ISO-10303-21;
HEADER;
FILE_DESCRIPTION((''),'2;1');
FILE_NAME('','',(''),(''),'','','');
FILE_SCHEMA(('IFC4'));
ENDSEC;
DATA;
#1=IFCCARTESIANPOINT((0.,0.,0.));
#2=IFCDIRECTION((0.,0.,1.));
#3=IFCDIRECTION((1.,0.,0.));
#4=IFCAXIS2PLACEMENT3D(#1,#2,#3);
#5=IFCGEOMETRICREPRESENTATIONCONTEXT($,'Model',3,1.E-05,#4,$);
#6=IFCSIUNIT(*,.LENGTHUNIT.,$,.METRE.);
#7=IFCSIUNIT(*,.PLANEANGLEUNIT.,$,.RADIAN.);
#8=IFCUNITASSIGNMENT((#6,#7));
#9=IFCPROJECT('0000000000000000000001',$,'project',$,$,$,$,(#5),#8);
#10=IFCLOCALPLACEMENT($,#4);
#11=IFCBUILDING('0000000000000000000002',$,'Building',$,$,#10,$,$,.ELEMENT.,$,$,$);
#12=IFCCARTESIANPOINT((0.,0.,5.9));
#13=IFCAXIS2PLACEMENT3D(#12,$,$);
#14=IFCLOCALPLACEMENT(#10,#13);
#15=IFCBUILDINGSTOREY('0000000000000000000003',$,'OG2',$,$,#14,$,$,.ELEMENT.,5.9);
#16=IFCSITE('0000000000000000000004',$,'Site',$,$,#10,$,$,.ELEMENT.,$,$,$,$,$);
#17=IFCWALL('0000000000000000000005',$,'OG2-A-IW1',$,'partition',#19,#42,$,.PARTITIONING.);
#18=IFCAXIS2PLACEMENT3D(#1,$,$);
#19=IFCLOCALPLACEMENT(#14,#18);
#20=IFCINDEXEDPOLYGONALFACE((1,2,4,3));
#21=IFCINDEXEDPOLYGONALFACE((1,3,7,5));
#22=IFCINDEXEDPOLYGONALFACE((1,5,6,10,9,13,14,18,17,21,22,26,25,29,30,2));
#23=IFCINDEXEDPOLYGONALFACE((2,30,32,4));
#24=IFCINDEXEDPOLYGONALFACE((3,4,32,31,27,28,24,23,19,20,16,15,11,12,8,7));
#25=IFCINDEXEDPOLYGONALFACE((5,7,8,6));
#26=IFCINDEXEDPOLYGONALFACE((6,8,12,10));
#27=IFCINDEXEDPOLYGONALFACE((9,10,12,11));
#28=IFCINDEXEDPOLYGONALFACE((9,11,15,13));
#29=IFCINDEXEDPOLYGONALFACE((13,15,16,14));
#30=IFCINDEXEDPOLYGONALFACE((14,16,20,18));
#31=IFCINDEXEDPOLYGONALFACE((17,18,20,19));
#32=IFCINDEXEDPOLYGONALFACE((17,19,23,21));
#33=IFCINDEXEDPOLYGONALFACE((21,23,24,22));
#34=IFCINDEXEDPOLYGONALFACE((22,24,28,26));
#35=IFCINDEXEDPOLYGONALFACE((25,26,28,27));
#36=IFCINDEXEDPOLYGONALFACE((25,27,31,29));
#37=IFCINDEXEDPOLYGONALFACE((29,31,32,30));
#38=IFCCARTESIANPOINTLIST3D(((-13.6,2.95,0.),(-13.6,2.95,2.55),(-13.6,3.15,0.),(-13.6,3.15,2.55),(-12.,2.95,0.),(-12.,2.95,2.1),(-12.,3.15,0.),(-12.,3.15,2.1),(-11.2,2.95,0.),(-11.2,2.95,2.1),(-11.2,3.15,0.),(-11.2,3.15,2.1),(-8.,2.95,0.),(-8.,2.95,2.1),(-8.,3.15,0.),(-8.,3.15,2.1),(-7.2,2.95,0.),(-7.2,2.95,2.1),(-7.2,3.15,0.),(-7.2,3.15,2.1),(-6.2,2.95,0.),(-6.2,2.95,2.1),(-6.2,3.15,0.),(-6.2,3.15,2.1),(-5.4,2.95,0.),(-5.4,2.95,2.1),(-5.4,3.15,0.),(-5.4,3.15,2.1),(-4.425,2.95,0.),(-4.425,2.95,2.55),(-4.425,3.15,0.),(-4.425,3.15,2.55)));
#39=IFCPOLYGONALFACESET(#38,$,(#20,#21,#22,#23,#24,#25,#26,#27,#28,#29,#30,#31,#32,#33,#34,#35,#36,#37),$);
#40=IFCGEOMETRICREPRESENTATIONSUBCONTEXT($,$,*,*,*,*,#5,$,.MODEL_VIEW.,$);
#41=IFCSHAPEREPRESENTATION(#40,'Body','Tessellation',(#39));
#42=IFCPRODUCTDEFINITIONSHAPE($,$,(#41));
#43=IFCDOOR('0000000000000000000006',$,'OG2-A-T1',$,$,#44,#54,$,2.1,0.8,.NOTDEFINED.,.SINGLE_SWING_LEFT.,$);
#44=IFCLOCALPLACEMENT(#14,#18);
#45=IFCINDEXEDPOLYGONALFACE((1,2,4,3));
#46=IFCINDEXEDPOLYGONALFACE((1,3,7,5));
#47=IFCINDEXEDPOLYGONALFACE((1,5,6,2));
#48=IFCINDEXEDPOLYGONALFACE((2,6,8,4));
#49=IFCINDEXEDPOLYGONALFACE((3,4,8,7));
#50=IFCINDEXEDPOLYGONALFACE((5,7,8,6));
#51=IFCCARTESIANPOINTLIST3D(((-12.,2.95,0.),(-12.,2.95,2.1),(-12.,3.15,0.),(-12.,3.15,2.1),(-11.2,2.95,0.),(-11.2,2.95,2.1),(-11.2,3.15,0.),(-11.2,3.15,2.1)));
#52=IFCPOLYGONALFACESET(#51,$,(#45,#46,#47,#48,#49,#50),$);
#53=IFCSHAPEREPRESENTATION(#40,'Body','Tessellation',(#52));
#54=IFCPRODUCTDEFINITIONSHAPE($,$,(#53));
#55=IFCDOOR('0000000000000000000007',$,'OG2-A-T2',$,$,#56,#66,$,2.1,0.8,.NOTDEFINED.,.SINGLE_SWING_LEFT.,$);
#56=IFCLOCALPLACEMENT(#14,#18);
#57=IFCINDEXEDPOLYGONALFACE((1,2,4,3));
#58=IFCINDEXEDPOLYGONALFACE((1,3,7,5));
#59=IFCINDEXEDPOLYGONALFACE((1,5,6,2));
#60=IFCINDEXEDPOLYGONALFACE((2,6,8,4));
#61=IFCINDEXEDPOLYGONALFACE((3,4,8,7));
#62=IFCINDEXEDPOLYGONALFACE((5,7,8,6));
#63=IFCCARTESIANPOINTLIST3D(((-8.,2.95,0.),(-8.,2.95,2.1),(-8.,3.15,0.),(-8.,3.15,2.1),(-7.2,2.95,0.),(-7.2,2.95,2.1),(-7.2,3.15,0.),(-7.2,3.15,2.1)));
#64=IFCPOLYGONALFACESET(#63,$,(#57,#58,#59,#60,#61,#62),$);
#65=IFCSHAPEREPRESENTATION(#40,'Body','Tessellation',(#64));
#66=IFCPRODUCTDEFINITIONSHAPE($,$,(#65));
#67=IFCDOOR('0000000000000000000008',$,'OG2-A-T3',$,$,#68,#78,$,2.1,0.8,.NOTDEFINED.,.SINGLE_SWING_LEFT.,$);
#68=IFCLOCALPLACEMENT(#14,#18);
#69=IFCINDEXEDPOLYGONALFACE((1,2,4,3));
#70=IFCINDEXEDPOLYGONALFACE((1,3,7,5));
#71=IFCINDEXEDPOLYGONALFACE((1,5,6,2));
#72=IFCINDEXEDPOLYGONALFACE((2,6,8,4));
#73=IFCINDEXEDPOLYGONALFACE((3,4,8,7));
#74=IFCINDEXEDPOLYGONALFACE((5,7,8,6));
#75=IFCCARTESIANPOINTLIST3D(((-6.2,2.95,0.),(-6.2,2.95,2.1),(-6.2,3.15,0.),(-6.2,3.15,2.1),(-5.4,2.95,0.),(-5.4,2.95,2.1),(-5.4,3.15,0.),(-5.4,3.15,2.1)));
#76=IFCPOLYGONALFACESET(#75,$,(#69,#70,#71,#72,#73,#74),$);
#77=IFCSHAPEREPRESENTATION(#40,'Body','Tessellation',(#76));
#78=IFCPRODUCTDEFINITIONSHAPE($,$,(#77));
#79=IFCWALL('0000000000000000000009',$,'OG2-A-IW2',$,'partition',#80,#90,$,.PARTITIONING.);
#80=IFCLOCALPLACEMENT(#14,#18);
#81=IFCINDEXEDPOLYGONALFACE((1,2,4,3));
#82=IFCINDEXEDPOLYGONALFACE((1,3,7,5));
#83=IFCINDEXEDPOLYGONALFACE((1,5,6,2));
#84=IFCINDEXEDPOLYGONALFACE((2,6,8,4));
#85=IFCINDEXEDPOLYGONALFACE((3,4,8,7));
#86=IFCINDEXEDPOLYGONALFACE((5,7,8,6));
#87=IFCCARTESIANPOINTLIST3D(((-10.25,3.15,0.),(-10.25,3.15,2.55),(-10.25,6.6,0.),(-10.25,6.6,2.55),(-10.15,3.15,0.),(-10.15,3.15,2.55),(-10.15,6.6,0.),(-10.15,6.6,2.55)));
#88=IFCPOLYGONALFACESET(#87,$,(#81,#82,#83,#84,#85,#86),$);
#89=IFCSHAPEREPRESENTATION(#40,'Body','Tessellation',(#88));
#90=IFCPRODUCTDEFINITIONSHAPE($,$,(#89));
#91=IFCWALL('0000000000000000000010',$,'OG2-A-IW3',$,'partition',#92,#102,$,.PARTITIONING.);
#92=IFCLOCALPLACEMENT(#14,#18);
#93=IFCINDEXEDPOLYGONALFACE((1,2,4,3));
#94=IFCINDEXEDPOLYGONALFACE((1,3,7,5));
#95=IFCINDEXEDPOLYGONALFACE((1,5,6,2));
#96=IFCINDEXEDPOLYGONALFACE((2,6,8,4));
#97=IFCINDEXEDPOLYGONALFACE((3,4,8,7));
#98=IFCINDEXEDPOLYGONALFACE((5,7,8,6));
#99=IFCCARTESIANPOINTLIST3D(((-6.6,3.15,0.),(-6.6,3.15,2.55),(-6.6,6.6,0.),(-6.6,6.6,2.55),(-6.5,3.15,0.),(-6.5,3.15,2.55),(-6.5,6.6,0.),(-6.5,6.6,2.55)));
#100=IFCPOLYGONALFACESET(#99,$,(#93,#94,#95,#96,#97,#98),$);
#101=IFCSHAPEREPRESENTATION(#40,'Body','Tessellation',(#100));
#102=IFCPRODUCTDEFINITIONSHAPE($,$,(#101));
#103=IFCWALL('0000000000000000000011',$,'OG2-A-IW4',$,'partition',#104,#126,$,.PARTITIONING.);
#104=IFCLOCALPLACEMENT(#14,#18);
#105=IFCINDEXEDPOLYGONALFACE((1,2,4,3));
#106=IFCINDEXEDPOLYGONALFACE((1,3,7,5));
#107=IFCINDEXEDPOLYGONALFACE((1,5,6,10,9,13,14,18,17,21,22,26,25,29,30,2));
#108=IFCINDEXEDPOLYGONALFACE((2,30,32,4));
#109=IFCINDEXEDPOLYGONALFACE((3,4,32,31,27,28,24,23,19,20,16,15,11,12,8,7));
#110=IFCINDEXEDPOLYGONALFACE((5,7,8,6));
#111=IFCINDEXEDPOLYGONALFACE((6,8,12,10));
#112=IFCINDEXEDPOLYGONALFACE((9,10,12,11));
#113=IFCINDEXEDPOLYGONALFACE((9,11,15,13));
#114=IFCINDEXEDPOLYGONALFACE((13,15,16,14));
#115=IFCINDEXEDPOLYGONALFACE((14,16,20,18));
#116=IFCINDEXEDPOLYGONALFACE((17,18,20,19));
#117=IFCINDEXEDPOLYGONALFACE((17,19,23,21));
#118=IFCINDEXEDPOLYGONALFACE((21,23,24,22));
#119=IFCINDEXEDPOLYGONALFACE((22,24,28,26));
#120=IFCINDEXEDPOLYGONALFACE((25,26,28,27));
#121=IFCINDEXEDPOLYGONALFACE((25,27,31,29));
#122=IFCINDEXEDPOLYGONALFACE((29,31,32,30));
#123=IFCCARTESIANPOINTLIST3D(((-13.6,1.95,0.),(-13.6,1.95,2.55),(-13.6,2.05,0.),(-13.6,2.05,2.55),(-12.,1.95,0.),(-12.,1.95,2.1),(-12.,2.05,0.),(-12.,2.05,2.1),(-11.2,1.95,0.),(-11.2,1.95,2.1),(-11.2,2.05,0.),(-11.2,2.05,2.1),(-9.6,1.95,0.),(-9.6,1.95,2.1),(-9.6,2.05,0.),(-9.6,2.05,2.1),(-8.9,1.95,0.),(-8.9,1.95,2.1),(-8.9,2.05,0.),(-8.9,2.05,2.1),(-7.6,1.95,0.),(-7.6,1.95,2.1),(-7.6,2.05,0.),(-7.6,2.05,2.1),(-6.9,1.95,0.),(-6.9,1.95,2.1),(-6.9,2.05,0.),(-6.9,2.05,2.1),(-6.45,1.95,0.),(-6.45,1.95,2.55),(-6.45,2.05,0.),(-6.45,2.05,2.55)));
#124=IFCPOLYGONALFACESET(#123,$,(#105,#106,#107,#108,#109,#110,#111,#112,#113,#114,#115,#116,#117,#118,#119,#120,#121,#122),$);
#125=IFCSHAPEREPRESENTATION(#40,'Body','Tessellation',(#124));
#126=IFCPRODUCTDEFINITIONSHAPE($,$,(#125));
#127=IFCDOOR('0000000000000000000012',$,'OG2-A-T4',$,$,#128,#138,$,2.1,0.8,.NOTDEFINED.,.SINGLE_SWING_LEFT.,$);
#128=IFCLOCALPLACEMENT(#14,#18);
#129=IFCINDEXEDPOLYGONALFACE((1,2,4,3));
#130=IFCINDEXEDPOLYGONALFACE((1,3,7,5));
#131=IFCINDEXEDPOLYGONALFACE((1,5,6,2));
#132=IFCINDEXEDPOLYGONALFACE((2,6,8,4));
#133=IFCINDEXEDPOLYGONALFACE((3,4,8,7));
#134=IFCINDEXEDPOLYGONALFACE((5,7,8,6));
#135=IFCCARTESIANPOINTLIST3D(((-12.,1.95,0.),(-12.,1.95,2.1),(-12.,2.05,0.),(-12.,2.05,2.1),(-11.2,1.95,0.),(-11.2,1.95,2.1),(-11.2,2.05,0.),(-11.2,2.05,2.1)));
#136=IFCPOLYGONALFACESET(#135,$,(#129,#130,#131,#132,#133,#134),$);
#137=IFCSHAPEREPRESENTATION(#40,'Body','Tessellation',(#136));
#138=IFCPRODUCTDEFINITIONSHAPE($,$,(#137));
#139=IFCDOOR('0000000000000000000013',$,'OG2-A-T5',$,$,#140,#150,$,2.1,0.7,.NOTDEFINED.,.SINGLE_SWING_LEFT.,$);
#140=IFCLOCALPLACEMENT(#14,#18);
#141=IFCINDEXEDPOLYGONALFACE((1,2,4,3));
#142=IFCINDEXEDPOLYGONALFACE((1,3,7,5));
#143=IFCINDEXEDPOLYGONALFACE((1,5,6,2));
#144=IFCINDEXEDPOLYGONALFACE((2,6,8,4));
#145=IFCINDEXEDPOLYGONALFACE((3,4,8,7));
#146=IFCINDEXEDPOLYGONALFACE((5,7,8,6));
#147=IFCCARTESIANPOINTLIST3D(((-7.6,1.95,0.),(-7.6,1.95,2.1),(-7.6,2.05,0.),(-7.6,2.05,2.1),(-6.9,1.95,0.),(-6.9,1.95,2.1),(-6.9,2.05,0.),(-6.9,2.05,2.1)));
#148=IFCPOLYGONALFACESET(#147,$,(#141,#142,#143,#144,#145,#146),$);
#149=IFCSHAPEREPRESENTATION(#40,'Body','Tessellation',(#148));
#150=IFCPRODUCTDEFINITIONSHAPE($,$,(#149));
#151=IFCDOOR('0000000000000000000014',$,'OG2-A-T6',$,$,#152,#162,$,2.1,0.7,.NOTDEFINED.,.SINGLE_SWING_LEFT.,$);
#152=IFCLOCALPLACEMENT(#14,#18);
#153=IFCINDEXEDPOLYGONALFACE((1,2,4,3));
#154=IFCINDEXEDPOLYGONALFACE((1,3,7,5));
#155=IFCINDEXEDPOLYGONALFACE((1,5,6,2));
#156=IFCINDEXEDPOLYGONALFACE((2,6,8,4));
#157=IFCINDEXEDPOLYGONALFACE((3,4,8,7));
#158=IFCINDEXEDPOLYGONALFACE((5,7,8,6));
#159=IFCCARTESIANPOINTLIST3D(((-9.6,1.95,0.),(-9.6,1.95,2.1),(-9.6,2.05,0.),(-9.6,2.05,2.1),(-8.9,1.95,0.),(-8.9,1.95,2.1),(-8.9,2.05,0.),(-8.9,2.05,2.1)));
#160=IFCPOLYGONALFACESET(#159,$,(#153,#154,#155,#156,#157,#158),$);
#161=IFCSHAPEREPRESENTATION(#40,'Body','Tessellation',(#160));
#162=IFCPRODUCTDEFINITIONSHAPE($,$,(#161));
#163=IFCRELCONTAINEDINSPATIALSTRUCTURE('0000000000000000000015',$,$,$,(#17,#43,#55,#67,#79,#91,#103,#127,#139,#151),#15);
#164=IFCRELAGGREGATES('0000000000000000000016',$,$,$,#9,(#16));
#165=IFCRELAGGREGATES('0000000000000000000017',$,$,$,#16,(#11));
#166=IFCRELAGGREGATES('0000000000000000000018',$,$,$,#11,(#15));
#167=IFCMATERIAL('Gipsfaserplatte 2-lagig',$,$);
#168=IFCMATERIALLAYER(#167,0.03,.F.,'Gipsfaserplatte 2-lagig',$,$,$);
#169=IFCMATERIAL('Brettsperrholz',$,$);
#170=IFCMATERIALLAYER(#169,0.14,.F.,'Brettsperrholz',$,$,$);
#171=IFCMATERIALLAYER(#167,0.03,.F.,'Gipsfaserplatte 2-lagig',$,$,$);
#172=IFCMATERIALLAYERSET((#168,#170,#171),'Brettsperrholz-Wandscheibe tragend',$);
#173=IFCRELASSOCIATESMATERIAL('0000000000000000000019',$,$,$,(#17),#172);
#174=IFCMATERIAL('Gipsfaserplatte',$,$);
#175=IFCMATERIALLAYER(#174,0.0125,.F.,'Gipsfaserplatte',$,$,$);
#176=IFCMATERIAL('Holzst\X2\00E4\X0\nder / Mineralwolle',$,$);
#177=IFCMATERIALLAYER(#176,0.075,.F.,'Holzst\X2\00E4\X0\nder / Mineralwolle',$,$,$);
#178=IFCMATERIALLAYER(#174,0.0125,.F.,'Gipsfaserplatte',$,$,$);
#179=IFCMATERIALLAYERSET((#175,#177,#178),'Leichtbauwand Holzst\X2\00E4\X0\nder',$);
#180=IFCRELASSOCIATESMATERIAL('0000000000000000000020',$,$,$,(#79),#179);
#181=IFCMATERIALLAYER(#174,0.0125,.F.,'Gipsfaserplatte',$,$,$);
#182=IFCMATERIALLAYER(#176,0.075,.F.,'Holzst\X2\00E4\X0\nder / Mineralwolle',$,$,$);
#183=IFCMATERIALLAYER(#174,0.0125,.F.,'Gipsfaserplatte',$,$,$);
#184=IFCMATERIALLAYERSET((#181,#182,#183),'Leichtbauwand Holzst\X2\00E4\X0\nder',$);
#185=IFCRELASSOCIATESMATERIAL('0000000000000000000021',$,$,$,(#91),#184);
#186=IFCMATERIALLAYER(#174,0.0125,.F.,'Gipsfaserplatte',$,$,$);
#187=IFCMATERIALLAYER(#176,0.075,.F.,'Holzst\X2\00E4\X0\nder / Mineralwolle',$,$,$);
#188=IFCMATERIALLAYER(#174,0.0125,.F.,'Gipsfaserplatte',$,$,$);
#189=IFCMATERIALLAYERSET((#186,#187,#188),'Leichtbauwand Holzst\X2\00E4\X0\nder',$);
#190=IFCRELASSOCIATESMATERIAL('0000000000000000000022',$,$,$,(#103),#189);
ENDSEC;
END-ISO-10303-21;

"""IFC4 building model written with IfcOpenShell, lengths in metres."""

from ifc_helpers import new_model, si_unit, frame, frame_2d, origin, origin_with_axes, place, context, subcontext, project, spatial, rectangle, extrude, material, layer, layer_set, element, fill, save


model = new_model("IFC4")

# Units and contexts
model_context = context("Model", 3, precision=1e-05, world=origin_with_axes())
sub_context = subcontext(model_context, None, None, "MODEL_VIEW")
ifc_project = project(units=[si_unit("LENGTHUNIT", "METRE"), si_unit("PLANEANGLEUNIT", "RADIAN")], contexts=[model_context])

# Site, building, storey
placement = place(None, origin_with_axes())
site = spatial("IfcSite", under=ifc_project, at=placement, Name="Site", CompositionType="ELEMENT")
building = spatial("IfcBuilding", under=site, at=placement, Name="Building", CompositionType="ELEMENT")
storey_placement = place(placement, frame((0.0, 0.0, 5.9)))
storey = spatial("IfcBuildingStorey", under=building, at=storey_placement, Name="OG2", CompositionType="ELEMENT", Elevation=5.9)

# Shared definitions
ifc_material_1 = material(Name="Gipsfaserplatte")

# Wall, openings, doors
ifc_material_2 = material(Name="Gipsfaserplatte 2-lagig")
ifc_layer_1 = layer(ifc_material_2, 0.03, ventilated=False, Name="Gipsfaserplatte 2-lagig")
ifc_material_3 = material(Name="Brettsperrholz")
ifc_layer_2 = layer(ifc_material_3, 0.14, ventilated=False, Name="Brettsperrholz")
ifc_layer_3 = layer(ifc_material_2, 0.03, ventilated=False, Name="Gipsfaserplatte 2-lagig")
ifc_layer_set_1 = layer_set([ifc_layer_1, ifc_layer_2, ifc_layer_3], Name="Brettsperrholz-Wandscheibe tragend")
wall_1_placement = place(storey_placement, frame((-13.6, 3.05, 0.0), z_axis=(0.0, 0.0, 1.0), x_axis=(1.0, 0.0, 0.0)))
wall_1 = element("IfcWall", 1, at=wall_1_placement, inside=storey, material=ifc_layer_set_1, Name="OG2-A-IW1", ObjectType="partition", PredefinedType="PARTITIONING", context=sub_context, shape_type="SweptSolid", body=[
    extrude(rectangle(XDim=9.175, YDim=0.2, at=frame_2d((4.5875, 0.0))), origin(), (0.0, 0.0, 1.0), 2.55),
])
opening_1_placement = place(wall_1_placement, frame((2.0, 0.15, 0.0), z_axis=(0.0, -1.0, 0.0), x_axis=(1.0, 0.0, 0.0)))
opening_1 = element("IfcOpeningElement", 2, at=opening_1_placement, cuts=wall_1, PredefinedType="OPENING", context=sub_context, shape_type="SweptSolid", body=[
    extrude(rectangle(XDim=0.8, YDim=2.1, at=frame_2d((0.0, 1.05))), origin(), (0.0, 0.0, 1.0), 0.3),
])
opening_2_placement = place(wall_1_placement, frame((6.0, 0.15, 0.0), z_axis=(0.0, -1.0, 0.0), x_axis=(1.0, 0.0, 0.0)))
opening_2 = element("IfcOpeningElement", 3, at=opening_2_placement, cuts=wall_1, PredefinedType="OPENING", context=sub_context, shape_type="SweptSolid", body=[
    extrude(rectangle(XDim=0.8, YDim=2.1, at=frame_2d((0.0, 1.05))), origin(), (0.0, 0.0, 1.0), 0.3),
])
opening_3_placement = place(wall_1_placement, frame((7.8, 0.15, 0.0), z_axis=(0.0, -1.0, 0.0), x_axis=(1.0, 0.0, 0.0)))
opening_3 = element("IfcOpeningElement", 4, at=opening_3_placement, cuts=wall_1, PredefinedType="OPENING", context=sub_context, shape_type="SweptSolid", body=[
    extrude(rectangle(XDim=0.8, YDim=2.1, at=frame_2d((0.0, 1.05))), origin(), (0.0, 0.0, 1.0), 0.3),
])
door_1_placement = place(wall_1_placement, frame((2.0, 0.1, 0.0), z_axis=(0.0, -1.0, 0.0), x_axis=(1.0, 0.0, 0.0)))
door_1 = element("IfcDoor", 5, at=door_1_placement, inside=storey, Name="OG2-A-T1", OperationType="SINGLE_SWING_LEFT", OverallHeight=2.1, OverallWidth=0.8, PredefinedType="NOTDEFINED", context=sub_context, shape_type="SweptSolid", body=[
    extrude(rectangle(XDim=0.8, YDim=2.1, at=frame_2d((0.0, 1.05))), origin(), (0.0, 0.0, 1.0), 0.2),
])
fill(opening_1, door_1)
door_2_placement = place(wall_1_placement, frame((6.0, 0.1, 0.0), z_axis=(0.0, -1.0, 0.0), x_axis=(1.0, 0.0, 0.0)))
door_2 = element("IfcDoor", 6, at=door_2_placement, inside=storey, Name="OG2-A-T2", OperationType="SINGLE_SWING_LEFT", OverallHeight=2.1, OverallWidth=0.8, PredefinedType="NOTDEFINED", context=sub_context, shape_type="SweptSolid", body=[
    extrude(rectangle(XDim=0.8, YDim=2.1, at=frame_2d((0.0, 1.05))), origin(), (0.0, 0.0, 1.0), 0.2),
])
fill(opening_2, door_2)
door_3_placement = place(wall_1_placement, frame((7.8, 0.1, 0.0), z_axis=(0.0, -1.0, 0.0), x_axis=(1.0, 0.0, 0.0)))
door_3 = element("IfcDoor", 7, at=door_3_placement, inside=storey, Name="OG2-A-T3", OperationType="SINGLE_SWING_LEFT", OverallHeight=2.1, OverallWidth=0.8, PredefinedType="NOTDEFINED", context=sub_context, shape_type="SweptSolid", body=[
    extrude(rectangle(XDim=0.8, YDim=2.1, at=frame_2d((0.0, 1.05))), origin(), (0.0, 0.0, 1.0), 0.2),
])
fill(opening_3, door_3)

# Walls
ifc_layer_4 = layer(ifc_material_1, 0.0125, ventilated=False, Name="Gipsfaserplatte")
ifc_material_4 = material(Name="Holzständer / Mineralwolle")
ifc_layer_5 = layer(ifc_material_4, 0.075, ventilated=False, Name="Holzständer / Mineralwolle")
ifc_layer_6 = layer(ifc_material_1, 0.0125, ventilated=False, Name="Gipsfaserplatte")
ifc_layer_set_2 = layer_set([ifc_layer_4, ifc_layer_5, ifc_layer_6], Name="Leichtbauwand Holzständer")
wall_2_placement = place(storey_placement, frame((-10.2, 3.15, 0.0), z_axis=(0.0, 0.0, 1.0), x_axis=(0.0, 1.0, 0.0)))
element("IfcWall", 8, at=wall_2_placement, inside=storey, material=ifc_layer_set_2, Name="OG2-A-IW2", ObjectType="partition", PredefinedType="PARTITIONING", context=sub_context, shape_type="SweptSolid", body=[
    extrude(rectangle(XDim=3.45, YDim=0.1, at=frame_2d((1.725, 0.0))), origin(), (0.0, 0.0, 1.0), 2.55),
])
ifc_layer_7 = layer(ifc_material_1, 0.0125, ventilated=False, Name="Gipsfaserplatte")
ifc_layer_8 = layer(ifc_material_4, 0.075, ventilated=False, Name="Holzständer / Mineralwolle")
ifc_layer_9 = layer(ifc_material_1, 0.0125, ventilated=False, Name="Gipsfaserplatte")
ifc_layer_set_3 = layer_set([ifc_layer_7, ifc_layer_8, ifc_layer_9], Name="Leichtbauwand Holzständer")
wall_3_placement = place(storey_placement, frame((-6.55, 3.15, 0.0), z_axis=(0.0, 0.0, 1.0), x_axis=(0.0, 1.0, 0.0)))
element("IfcWall", 9, at=wall_3_placement, inside=storey, material=ifc_layer_set_3, Name="OG2-A-IW3", ObjectType="partition", PredefinedType="PARTITIONING", context=sub_context, shape_type="SweptSolid", body=[
    extrude(rectangle(XDim=3.45, YDim=0.1, at=frame_2d((1.725, 0.0))), origin(), (0.0, 0.0, 1.0), 2.55),
])

# Wall, openings, doors
ifc_layer_10 = layer(ifc_material_1, 0.0125, ventilated=False, Name="Gipsfaserplatte")
ifc_layer_11 = layer(ifc_material_4, 0.075, ventilated=False, Name="Holzständer / Mineralwolle")
ifc_layer_12 = layer(ifc_material_1, 0.0125, ventilated=False, Name="Gipsfaserplatte")
ifc_layer_set_4 = layer_set([ifc_layer_10, ifc_layer_11, ifc_layer_12], Name="Leichtbauwand Holzständer")
wall_4_placement = place(storey_placement, frame((-13.6, 2.0, 0.0), z_axis=(0.0, 0.0, 1.0), x_axis=(1.0, 0.0, 0.0)))
wall_4 = element("IfcWall", 10, at=wall_4_placement, inside=storey, material=ifc_layer_set_4, Name="OG2-A-IW4", ObjectType="partition", PredefinedType="PARTITIONING", context=sub_context, shape_type="SweptSolid", body=[
    extrude(rectangle(XDim=7.15, YDim=0.1, at=frame_2d((3.575, 0.0))), origin(), (0.0, 0.0, 1.0), 2.55),
])
opening_4_placement = place(wall_4_placement, frame((2.0, 0.1, 0.0), z_axis=(0.0, -1.0, 0.0), x_axis=(1.0, 0.0, 0.0)))
opening_4 = element("IfcOpeningElement", 11, at=opening_4_placement, cuts=wall_4, PredefinedType="OPENING", context=sub_context, shape_type="SweptSolid", body=[
    extrude(rectangle(XDim=0.8, YDim=2.1, at=frame_2d((0.0, 1.05))), origin(), (0.0, 0.0, 1.0), 0.2),
])
opening_5_placement = place(wall_4_placement, frame((6.35, 0.1, 0.0), z_axis=(0.0, -1.0, 0.0), x_axis=(1.0, 0.0, 0.0)))
opening_5 = element("IfcOpeningElement", 12, at=opening_5_placement, cuts=wall_4, PredefinedType="OPENING", context=sub_context, shape_type="SweptSolid", body=[
    extrude(rectangle(XDim=0.7, YDim=2.1, at=frame_2d((0.0, 1.05))), origin(), (0.0, 0.0, 1.0), 0.2),
])
opening_6_placement = place(wall_4_placement, frame((4.35, 0.1, 0.0), z_axis=(0.0, -1.0, 0.0), x_axis=(1.0, 0.0, 0.0)))
opening_6 = element("IfcOpeningElement", 13, at=opening_6_placement, cuts=wall_4, PredefinedType="OPENING", context=sub_context, shape_type="SweptSolid", body=[
    extrude(rectangle(XDim=0.7, YDim=2.1, at=frame_2d((0.0, 1.05))), origin(), (0.0, 0.0, 1.0), 0.2),
])
door_4_placement = place(wall_4_placement, frame((2.0, 0.05, 0.0), z_axis=(0.0, -1.0, 0.0), x_axis=(1.0, 0.0, 0.0)))
door_4 = element("IfcDoor", 14, at=door_4_placement, inside=storey, Name="OG2-A-T4", OperationType="SINGLE_SWING_LEFT", OverallHeight=2.1, OverallWidth=0.8, PredefinedType="NOTDEFINED", context=sub_context, shape_type="SweptSolid", body=[
    extrude(rectangle(XDim=0.8, YDim=2.1, at=frame_2d((0.0, 1.05))), origin(), (0.0, 0.0, 1.0), 0.1),
])
fill(opening_4, door_4)
door_5_placement = place(wall_4_placement, frame((6.35, 0.05, 0.0), z_axis=(0.0, -1.0, 0.0), x_axis=(1.0, 0.0, 0.0)))
door_5 = element("IfcDoor", 15, at=door_5_placement, inside=storey, Name="OG2-A-T5", OperationType="SINGLE_SWING_LEFT", OverallHeight=2.1, OverallWidth=0.7, PredefinedType="NOTDEFINED", context=sub_context, shape_type="SweptSolid", body=[
    extrude(rectangle(XDim=0.7, YDim=2.1, at=frame_2d((0.0, 1.05))), origin(), (0.0, 0.0, 1.0), 0.1),
])
fill(opening_5, door_5)
door_6_placement = place(wall_4_placement, frame((4.35, 0.05, 0.0), z_axis=(0.0, -1.0, 0.0), x_axis=(1.0, 0.0, 0.0)))
door_6 = element("IfcDoor", 16, at=door_6_placement, inside=storey, Name="OG2-A-T6", OperationType="SINGLE_SWING_LEFT", OverallHeight=2.1, OverallWidth=0.7, PredefinedType="NOTDEFINED", context=sub_context, shape_type="SweptSolid", body=[
    extrude(rectangle(XDim=0.7, YDim=2.1, at=frame_2d((0.0, 1.05))), origin(), (0.0, 0.0, 1.0), 0.1),
])
fill(opening_6, door_6)

save(model, "model.ifc")
